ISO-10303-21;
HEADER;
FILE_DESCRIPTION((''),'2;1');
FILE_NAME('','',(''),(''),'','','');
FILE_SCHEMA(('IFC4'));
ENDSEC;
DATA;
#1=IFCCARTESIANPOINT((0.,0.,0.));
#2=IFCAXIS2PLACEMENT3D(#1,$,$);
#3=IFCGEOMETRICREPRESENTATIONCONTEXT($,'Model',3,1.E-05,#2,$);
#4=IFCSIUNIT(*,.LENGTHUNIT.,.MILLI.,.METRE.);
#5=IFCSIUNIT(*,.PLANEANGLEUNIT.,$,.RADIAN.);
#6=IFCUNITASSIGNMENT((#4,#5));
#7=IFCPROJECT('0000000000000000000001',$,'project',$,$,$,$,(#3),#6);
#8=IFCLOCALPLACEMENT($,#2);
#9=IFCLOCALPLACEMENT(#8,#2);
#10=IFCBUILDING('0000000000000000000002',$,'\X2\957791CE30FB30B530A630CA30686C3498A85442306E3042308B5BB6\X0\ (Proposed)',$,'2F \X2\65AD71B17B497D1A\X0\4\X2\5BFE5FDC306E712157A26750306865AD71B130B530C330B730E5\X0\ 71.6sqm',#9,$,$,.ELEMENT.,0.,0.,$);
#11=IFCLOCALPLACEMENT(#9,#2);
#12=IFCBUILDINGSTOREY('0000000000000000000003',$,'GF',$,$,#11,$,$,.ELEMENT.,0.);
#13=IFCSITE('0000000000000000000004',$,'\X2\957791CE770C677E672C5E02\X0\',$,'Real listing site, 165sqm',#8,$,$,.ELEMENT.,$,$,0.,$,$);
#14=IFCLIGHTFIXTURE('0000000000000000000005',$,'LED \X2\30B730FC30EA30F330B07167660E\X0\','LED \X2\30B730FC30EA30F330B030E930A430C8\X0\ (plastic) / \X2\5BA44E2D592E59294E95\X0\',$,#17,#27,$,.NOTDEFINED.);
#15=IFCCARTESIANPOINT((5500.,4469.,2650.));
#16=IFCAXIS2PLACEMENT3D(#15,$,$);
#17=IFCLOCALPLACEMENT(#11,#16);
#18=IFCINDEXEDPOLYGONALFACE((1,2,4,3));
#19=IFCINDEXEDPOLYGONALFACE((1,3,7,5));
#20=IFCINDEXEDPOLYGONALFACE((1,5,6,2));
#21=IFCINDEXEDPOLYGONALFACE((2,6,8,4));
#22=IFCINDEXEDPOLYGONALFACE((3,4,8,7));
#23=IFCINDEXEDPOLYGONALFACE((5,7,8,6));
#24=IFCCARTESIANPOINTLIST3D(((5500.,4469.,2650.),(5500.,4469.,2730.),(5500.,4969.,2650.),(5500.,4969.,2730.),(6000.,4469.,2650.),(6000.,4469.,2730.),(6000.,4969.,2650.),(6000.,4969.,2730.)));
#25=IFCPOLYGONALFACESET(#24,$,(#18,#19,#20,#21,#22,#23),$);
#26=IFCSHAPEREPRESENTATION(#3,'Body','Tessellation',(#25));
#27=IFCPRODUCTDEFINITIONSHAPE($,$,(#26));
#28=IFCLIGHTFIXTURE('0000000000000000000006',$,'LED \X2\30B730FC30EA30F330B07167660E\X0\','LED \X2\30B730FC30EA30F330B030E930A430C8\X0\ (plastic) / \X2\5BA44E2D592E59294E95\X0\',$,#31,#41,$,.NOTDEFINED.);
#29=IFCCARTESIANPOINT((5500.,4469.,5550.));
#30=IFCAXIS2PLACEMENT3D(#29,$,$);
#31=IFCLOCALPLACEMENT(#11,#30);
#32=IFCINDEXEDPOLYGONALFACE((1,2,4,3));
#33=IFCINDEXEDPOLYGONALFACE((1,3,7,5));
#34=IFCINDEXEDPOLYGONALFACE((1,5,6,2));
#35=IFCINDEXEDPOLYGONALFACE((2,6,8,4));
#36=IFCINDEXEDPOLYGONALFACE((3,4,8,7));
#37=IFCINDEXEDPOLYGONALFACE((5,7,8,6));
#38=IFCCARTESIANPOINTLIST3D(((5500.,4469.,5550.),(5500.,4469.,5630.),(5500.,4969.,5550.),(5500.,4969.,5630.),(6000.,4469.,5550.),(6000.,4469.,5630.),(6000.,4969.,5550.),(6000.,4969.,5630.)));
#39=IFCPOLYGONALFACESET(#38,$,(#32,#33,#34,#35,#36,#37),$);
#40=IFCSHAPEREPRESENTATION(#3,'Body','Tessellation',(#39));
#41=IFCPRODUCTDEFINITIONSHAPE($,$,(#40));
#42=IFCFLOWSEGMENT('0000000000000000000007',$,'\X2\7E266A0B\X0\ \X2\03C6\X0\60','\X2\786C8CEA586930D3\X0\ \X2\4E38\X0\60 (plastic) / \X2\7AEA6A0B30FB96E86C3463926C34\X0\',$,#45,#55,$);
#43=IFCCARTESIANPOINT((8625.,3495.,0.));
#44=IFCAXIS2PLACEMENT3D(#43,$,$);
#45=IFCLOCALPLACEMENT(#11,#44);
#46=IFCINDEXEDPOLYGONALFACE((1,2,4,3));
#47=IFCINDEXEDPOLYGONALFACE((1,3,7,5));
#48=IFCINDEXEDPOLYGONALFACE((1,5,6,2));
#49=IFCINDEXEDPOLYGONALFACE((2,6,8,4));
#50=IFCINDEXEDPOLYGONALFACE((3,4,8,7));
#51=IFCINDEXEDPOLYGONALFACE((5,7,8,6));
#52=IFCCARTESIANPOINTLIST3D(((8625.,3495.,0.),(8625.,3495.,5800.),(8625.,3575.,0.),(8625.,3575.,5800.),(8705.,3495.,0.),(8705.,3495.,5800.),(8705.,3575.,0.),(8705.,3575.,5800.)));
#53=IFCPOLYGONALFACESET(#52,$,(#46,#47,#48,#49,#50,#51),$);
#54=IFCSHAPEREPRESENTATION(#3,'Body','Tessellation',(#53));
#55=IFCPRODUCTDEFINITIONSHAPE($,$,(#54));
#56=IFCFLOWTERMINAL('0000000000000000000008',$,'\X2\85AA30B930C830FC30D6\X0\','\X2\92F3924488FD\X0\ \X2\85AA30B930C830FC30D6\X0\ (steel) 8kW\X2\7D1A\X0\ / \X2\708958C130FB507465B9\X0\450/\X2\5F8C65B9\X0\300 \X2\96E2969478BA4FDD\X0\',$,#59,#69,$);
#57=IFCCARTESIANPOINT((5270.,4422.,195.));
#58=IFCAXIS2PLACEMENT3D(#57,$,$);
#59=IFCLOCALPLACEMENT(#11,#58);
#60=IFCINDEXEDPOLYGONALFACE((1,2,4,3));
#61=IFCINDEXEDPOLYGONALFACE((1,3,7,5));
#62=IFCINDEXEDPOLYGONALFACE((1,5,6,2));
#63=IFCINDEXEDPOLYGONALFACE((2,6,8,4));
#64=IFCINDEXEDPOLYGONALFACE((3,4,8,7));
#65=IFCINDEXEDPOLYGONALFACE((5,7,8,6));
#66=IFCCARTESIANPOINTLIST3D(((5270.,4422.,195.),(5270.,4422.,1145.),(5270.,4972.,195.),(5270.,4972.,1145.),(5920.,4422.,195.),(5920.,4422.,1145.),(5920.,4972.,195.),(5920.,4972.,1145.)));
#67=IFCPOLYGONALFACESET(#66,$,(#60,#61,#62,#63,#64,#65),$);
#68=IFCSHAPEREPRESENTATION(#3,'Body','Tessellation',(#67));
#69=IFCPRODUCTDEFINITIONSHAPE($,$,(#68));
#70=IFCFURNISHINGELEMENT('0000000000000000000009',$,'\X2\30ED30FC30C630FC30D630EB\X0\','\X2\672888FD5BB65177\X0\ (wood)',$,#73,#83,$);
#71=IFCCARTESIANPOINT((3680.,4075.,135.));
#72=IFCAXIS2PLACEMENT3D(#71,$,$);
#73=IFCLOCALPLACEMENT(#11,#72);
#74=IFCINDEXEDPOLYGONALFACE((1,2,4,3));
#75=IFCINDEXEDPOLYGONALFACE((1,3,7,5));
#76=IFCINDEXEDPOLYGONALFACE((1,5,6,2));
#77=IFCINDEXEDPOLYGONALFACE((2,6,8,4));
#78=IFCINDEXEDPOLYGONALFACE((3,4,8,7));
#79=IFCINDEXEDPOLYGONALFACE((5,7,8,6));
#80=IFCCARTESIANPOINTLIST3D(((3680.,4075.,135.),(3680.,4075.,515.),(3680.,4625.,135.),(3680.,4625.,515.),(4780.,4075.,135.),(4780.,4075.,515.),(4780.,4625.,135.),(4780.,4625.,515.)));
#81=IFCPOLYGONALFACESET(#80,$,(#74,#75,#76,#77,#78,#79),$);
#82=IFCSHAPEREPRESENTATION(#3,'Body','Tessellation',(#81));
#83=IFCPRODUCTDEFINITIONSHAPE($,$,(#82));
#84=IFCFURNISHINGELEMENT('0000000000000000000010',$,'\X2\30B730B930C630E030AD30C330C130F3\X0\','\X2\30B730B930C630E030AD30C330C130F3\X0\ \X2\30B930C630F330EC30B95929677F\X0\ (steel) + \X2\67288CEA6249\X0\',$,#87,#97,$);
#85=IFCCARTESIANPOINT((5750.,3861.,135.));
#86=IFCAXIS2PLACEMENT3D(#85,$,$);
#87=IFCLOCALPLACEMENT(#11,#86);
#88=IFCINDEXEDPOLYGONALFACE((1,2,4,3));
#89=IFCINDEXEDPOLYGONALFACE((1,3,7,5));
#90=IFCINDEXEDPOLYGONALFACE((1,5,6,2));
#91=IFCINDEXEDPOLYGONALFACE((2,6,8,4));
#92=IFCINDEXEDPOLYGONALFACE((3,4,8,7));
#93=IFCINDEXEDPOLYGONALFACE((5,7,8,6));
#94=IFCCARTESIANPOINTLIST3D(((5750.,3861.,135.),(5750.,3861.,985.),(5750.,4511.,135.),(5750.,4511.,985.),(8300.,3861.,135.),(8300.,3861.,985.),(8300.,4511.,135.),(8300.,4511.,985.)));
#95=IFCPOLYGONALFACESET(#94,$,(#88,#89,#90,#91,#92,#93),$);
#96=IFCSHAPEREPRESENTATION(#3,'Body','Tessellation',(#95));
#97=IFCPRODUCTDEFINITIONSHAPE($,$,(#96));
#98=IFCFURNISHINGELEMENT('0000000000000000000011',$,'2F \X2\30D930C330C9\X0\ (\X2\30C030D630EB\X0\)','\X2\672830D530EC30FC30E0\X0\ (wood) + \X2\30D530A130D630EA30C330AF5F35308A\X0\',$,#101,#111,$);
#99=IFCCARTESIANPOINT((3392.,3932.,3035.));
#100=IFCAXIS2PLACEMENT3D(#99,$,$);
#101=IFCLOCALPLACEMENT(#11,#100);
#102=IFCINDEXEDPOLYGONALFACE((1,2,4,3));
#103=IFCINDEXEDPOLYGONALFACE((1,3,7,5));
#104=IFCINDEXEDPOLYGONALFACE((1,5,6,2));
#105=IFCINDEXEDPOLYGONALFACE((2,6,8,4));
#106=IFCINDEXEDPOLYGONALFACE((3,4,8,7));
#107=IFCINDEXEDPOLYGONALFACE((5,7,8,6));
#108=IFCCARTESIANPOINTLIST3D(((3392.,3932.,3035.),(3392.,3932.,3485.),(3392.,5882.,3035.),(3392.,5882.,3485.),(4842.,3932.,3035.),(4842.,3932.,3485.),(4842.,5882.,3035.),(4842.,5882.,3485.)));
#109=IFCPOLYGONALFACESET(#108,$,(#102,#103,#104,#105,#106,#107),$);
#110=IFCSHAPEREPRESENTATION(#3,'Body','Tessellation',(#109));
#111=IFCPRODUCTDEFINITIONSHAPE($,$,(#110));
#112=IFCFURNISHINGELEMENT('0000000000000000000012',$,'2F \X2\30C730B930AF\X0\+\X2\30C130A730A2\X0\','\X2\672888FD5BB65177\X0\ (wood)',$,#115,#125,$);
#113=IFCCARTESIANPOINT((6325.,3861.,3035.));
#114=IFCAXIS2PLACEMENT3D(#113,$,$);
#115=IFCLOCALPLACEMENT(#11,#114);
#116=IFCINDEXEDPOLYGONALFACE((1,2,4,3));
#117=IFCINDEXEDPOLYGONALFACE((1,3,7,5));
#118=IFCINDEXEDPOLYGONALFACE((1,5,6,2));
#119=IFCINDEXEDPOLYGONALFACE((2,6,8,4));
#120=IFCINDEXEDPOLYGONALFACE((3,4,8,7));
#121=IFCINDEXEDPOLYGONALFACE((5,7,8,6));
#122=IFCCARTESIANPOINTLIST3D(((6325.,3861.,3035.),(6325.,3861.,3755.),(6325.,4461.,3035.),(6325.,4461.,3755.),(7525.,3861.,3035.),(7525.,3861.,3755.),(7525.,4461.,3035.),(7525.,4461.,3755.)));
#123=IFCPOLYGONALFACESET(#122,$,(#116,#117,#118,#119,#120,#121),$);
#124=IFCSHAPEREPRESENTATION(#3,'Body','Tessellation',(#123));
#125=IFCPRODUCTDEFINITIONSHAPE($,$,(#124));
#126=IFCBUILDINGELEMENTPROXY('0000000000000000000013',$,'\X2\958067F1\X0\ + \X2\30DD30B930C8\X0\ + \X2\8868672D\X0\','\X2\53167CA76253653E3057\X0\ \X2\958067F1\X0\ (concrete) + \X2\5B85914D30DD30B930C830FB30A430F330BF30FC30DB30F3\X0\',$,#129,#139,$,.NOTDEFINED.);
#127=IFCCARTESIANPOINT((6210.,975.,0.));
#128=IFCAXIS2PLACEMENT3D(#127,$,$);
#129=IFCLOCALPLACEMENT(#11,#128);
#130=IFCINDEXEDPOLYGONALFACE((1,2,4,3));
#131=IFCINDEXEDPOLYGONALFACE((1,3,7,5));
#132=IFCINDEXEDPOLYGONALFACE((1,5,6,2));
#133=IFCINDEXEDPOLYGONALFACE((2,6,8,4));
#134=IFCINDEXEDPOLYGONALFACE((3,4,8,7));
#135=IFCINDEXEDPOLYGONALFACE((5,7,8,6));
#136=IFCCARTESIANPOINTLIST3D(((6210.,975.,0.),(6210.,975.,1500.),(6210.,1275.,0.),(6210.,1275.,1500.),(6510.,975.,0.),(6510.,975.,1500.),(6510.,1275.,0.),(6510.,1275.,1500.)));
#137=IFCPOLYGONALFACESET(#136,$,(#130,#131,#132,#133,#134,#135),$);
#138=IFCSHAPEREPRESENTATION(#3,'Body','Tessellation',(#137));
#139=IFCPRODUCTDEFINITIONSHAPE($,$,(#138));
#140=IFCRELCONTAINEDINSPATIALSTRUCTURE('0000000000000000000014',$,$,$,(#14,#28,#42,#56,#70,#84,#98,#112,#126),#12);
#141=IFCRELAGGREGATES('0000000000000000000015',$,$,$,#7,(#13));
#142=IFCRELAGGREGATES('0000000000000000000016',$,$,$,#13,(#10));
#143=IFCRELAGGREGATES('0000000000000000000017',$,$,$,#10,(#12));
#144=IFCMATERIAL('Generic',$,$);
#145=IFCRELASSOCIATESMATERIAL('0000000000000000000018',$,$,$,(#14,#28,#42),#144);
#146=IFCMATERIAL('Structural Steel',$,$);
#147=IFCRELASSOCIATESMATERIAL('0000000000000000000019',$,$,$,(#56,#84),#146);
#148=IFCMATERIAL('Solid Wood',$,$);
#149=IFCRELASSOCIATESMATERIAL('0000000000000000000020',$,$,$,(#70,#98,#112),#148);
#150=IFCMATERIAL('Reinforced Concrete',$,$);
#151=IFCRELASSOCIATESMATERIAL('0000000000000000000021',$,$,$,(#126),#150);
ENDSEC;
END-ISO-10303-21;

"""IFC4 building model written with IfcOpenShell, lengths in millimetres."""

from ifc_helpers import new_model, si_unit, frame, frame_2d, origin, place, context, project, spatial, rectangle, extrude, material, element, save


model = new_model("IFC4")

# Units and contexts
model_context = context("Model", 3, precision=1e-05, world=origin())
ifc_project = project(units=[si_unit("LENGTHUNIT", "METRE", prefix="MILLI"), si_unit("PLANEANGLEUNIT", "RADIAN")], contexts=[model_context])

# Site, building, storey
site_placement = place(None, origin())
site = spatial("IfcSite", under=ifc_project, at=site_placement, Name="長野県松本市", ObjectType="Real listing site, 165sqm", CompositionType="ELEMENT", RefElevation=0.0)
building_placement = place(site_placement, origin())
building = spatial("IfcBuilding", under=site, at=building_placement, Name="長野・サウナと水風呂のある家 (Proposed)", ObjectType="2F 断熱等級4対応の無垢材と断熱サッシュ 71.6sqm", CompositionType="ELEMENT", ElevationOfRefHeight=0.0, ElevationOfTerrain=0.0)
storey_placement = place(building_placement, origin())
storey = spatial("IfcBuildingStorey", under=building, at=storey_placement, Name="GF", CompositionType="ELEMENT", Elevation=0.0)

# Shared definitions
ifc_material_1 = material(Name="Solid Wood")

# Shared definitions
ifc_material_2 = material(Name="Reinforced Concrete")

# Shared definitions
ifc_material_3 = material(Name="Structural Steel")

# Shared definitions
ifc_material_4 = material(Name="Generic")

# Light fixtures
light_fixture_1_placement = place(storey_placement, frame((5500.0, 4469.0, 2650.0)))
element("IfcLightFixture", 1, at=light_fixture_1_placement, inside=storey, material=ifc_material_4, Name="LED シーリング照明", Description="LED シーリングライト (plastic) / 室中央天井", PredefinedType="NOTDEFINED", context=model_context, shape_type="SweptSolid", body=[
    extrude(rectangle(XDim=500.0, YDim=500.0, at=frame_2d((250.0, 250.0))), frame((5500.0, 4469.0, 2650.0)), (0.0, 0.0, 1.0), 80.0),
])
light_fixture_2_placement = place(storey_placement, frame((5500.0, 4469.0, 5550.0)))
element("IfcLightFixture", 2, at=light_fixture_2_placement, inside=storey, material=ifc_material_4, Name="LED シーリング照明", Description="LED シーリングライト (plastic) / 室中央天井", PredefinedType="NOTDEFINED", context=model_context, shape_type="SweptSolid", body=[
    extrude(rectangle(XDim=500.0, YDim=500.0, at=frame_2d((250.0, 250.0))), frame((5500.0, 4469.0, 5550.0)), (0.0, 0.0, 1.0), 80.0),
])

# Flow segment
flow_segment_placement = place(storey_placement, frame((8625.0, 3495.0, 0.0)))
element("IfcFlowSegment", 3, at=flow_segment_placement, inside=storey, material=ifc_material_4, Name="縦樋 φ60", Description="硬質塩ビ 丸60 (plastic) / 竪樋・雨水排水", context=model_context, shape_type="SweptSolid", body=[
    extrude(rectangle(XDim=80.0, YDim=80.0, at=frame_2d((40.0, 40.0))), frame((8625.0, 3495.0, 0.0)), (0.0, 0.0, 1.0), 5800.0),
])

# Flow terminal
flow_terminal_1_placement = place(storey_placement, frame((5270.0, 4422.0, 195.0)))
element("IfcFlowTerminal", 4, at=flow_terminal_1_placement, inside=storey, material=ifc_material_3, Name="薪ストーブ", Description="鋳鉄製 薪ストーブ (steel) 8kW級 / 炉壁・側方450/後方300 離隔確保", context=model_context, shape_type="SweptSolid", body=[
    extrude(rectangle(XDim=650.0, YDim=550.0, at=frame_2d((325.0, 275.0))), frame((5270.0, 4422.0, 195.0)), (0.0, 0.0, 1.0), 950.0),
])

# Furnishing elements
furnishing_1_placement = place(storey_placement, frame((3680.0, 4075.0, 135.0)))
element("IfcFurnishingElement", 5, at=furnishing_1_placement, inside=storey, material=ifc_material_1, Name="ローテーブル", Description="木製家具 (wood)", context=model_context, shape_type="SweptSolid", body=[
    extrude(rectangle(XDim=1100.0, YDim=550.0, at=frame_2d((550.0, 275.0))), frame((3680.0, 4075.0, 135.0)), (0.0, 0.0, 1.0), 380.0),
])
furnishing_2_placement = place(storey_placement, frame((5750.0, 3861.0, 135.0)))
element("IfcFurnishingElement", 6, at=furnishing_2_placement, inside=storey, material=ifc_material_3, Name="システムキッチン", Description="システムキッチン ステンレス天板 (steel) + 木質扉", context=model_context, shape_type="SweptSolid", body=[
    extrude(rectangle(XDim=2550.0, YDim=650.0, at=frame_2d((1275.0, 325.0))), frame((5750.0, 3861.0, 135.0)), (0.0, 0.0, 1.0), 850.0),
])
furnishing_3_placement = place(storey_placement, frame((3392.0, 3932.0, 3035.0)))
element("IfcFurnishingElement", 7, at=furnishing_3_placement, inside=storey, material=ifc_material_1, Name="2F ベッド (ダブル)", Description="木フレーム (wood) + ファブリック張り", context=model_context, shape_type="SweptSolid", body=[
    extrude(rectangle(XDim=1450.0, YDim=1950.0, at=frame_2d((725.0, 975.0))), frame((3392.0, 3932.0, 3035.0)), (0.0, 0.0, 1.0), 450.0),
])
furnishing_4_placement = place(storey_placement, frame((6325.0, 3861.0, 3035.0)))
element("IfcFurnishingElement", 8, at=furnishing_4_placement, inside=storey, material=ifc_material_1, Name="2F デスク+チェア", Description="木製家具 (wood)", context=model_context, shape_type="SweptSolid", body=[
    extrude(rectangle(XDim=1200.0, YDim=600.0, at=frame_2d((600.0, 300.0))), frame((6325.0, 3861.0, 3035.0)), (0.0, 0.0, 1.0), 720.0),
])

# Building element proxy
proxy_placement = place(storey_placement, frame((6210.0, 975.0, 0.0)))
element("IfcBuildingElementProxy", 9, at=proxy_placement, inside=storey, material=ifc_material_2, Name="門柱 + ポスト + 表札", Description="化粧打放し 門柱 (concrete) + 宅配ポスト・インターホン", PredefinedType="NOTDEFINED", context=model_context, shape_type="SweptSolid", body=[
    extrude(rectangle(XDim=300.0, YDim=300.0, at=frame_2d((150.0, 150.0))), frame((6210.0, 975.0, 0.0)), (0.0, 0.0, 1.0), 1500.0),
])

save(model, "model.ifc")
